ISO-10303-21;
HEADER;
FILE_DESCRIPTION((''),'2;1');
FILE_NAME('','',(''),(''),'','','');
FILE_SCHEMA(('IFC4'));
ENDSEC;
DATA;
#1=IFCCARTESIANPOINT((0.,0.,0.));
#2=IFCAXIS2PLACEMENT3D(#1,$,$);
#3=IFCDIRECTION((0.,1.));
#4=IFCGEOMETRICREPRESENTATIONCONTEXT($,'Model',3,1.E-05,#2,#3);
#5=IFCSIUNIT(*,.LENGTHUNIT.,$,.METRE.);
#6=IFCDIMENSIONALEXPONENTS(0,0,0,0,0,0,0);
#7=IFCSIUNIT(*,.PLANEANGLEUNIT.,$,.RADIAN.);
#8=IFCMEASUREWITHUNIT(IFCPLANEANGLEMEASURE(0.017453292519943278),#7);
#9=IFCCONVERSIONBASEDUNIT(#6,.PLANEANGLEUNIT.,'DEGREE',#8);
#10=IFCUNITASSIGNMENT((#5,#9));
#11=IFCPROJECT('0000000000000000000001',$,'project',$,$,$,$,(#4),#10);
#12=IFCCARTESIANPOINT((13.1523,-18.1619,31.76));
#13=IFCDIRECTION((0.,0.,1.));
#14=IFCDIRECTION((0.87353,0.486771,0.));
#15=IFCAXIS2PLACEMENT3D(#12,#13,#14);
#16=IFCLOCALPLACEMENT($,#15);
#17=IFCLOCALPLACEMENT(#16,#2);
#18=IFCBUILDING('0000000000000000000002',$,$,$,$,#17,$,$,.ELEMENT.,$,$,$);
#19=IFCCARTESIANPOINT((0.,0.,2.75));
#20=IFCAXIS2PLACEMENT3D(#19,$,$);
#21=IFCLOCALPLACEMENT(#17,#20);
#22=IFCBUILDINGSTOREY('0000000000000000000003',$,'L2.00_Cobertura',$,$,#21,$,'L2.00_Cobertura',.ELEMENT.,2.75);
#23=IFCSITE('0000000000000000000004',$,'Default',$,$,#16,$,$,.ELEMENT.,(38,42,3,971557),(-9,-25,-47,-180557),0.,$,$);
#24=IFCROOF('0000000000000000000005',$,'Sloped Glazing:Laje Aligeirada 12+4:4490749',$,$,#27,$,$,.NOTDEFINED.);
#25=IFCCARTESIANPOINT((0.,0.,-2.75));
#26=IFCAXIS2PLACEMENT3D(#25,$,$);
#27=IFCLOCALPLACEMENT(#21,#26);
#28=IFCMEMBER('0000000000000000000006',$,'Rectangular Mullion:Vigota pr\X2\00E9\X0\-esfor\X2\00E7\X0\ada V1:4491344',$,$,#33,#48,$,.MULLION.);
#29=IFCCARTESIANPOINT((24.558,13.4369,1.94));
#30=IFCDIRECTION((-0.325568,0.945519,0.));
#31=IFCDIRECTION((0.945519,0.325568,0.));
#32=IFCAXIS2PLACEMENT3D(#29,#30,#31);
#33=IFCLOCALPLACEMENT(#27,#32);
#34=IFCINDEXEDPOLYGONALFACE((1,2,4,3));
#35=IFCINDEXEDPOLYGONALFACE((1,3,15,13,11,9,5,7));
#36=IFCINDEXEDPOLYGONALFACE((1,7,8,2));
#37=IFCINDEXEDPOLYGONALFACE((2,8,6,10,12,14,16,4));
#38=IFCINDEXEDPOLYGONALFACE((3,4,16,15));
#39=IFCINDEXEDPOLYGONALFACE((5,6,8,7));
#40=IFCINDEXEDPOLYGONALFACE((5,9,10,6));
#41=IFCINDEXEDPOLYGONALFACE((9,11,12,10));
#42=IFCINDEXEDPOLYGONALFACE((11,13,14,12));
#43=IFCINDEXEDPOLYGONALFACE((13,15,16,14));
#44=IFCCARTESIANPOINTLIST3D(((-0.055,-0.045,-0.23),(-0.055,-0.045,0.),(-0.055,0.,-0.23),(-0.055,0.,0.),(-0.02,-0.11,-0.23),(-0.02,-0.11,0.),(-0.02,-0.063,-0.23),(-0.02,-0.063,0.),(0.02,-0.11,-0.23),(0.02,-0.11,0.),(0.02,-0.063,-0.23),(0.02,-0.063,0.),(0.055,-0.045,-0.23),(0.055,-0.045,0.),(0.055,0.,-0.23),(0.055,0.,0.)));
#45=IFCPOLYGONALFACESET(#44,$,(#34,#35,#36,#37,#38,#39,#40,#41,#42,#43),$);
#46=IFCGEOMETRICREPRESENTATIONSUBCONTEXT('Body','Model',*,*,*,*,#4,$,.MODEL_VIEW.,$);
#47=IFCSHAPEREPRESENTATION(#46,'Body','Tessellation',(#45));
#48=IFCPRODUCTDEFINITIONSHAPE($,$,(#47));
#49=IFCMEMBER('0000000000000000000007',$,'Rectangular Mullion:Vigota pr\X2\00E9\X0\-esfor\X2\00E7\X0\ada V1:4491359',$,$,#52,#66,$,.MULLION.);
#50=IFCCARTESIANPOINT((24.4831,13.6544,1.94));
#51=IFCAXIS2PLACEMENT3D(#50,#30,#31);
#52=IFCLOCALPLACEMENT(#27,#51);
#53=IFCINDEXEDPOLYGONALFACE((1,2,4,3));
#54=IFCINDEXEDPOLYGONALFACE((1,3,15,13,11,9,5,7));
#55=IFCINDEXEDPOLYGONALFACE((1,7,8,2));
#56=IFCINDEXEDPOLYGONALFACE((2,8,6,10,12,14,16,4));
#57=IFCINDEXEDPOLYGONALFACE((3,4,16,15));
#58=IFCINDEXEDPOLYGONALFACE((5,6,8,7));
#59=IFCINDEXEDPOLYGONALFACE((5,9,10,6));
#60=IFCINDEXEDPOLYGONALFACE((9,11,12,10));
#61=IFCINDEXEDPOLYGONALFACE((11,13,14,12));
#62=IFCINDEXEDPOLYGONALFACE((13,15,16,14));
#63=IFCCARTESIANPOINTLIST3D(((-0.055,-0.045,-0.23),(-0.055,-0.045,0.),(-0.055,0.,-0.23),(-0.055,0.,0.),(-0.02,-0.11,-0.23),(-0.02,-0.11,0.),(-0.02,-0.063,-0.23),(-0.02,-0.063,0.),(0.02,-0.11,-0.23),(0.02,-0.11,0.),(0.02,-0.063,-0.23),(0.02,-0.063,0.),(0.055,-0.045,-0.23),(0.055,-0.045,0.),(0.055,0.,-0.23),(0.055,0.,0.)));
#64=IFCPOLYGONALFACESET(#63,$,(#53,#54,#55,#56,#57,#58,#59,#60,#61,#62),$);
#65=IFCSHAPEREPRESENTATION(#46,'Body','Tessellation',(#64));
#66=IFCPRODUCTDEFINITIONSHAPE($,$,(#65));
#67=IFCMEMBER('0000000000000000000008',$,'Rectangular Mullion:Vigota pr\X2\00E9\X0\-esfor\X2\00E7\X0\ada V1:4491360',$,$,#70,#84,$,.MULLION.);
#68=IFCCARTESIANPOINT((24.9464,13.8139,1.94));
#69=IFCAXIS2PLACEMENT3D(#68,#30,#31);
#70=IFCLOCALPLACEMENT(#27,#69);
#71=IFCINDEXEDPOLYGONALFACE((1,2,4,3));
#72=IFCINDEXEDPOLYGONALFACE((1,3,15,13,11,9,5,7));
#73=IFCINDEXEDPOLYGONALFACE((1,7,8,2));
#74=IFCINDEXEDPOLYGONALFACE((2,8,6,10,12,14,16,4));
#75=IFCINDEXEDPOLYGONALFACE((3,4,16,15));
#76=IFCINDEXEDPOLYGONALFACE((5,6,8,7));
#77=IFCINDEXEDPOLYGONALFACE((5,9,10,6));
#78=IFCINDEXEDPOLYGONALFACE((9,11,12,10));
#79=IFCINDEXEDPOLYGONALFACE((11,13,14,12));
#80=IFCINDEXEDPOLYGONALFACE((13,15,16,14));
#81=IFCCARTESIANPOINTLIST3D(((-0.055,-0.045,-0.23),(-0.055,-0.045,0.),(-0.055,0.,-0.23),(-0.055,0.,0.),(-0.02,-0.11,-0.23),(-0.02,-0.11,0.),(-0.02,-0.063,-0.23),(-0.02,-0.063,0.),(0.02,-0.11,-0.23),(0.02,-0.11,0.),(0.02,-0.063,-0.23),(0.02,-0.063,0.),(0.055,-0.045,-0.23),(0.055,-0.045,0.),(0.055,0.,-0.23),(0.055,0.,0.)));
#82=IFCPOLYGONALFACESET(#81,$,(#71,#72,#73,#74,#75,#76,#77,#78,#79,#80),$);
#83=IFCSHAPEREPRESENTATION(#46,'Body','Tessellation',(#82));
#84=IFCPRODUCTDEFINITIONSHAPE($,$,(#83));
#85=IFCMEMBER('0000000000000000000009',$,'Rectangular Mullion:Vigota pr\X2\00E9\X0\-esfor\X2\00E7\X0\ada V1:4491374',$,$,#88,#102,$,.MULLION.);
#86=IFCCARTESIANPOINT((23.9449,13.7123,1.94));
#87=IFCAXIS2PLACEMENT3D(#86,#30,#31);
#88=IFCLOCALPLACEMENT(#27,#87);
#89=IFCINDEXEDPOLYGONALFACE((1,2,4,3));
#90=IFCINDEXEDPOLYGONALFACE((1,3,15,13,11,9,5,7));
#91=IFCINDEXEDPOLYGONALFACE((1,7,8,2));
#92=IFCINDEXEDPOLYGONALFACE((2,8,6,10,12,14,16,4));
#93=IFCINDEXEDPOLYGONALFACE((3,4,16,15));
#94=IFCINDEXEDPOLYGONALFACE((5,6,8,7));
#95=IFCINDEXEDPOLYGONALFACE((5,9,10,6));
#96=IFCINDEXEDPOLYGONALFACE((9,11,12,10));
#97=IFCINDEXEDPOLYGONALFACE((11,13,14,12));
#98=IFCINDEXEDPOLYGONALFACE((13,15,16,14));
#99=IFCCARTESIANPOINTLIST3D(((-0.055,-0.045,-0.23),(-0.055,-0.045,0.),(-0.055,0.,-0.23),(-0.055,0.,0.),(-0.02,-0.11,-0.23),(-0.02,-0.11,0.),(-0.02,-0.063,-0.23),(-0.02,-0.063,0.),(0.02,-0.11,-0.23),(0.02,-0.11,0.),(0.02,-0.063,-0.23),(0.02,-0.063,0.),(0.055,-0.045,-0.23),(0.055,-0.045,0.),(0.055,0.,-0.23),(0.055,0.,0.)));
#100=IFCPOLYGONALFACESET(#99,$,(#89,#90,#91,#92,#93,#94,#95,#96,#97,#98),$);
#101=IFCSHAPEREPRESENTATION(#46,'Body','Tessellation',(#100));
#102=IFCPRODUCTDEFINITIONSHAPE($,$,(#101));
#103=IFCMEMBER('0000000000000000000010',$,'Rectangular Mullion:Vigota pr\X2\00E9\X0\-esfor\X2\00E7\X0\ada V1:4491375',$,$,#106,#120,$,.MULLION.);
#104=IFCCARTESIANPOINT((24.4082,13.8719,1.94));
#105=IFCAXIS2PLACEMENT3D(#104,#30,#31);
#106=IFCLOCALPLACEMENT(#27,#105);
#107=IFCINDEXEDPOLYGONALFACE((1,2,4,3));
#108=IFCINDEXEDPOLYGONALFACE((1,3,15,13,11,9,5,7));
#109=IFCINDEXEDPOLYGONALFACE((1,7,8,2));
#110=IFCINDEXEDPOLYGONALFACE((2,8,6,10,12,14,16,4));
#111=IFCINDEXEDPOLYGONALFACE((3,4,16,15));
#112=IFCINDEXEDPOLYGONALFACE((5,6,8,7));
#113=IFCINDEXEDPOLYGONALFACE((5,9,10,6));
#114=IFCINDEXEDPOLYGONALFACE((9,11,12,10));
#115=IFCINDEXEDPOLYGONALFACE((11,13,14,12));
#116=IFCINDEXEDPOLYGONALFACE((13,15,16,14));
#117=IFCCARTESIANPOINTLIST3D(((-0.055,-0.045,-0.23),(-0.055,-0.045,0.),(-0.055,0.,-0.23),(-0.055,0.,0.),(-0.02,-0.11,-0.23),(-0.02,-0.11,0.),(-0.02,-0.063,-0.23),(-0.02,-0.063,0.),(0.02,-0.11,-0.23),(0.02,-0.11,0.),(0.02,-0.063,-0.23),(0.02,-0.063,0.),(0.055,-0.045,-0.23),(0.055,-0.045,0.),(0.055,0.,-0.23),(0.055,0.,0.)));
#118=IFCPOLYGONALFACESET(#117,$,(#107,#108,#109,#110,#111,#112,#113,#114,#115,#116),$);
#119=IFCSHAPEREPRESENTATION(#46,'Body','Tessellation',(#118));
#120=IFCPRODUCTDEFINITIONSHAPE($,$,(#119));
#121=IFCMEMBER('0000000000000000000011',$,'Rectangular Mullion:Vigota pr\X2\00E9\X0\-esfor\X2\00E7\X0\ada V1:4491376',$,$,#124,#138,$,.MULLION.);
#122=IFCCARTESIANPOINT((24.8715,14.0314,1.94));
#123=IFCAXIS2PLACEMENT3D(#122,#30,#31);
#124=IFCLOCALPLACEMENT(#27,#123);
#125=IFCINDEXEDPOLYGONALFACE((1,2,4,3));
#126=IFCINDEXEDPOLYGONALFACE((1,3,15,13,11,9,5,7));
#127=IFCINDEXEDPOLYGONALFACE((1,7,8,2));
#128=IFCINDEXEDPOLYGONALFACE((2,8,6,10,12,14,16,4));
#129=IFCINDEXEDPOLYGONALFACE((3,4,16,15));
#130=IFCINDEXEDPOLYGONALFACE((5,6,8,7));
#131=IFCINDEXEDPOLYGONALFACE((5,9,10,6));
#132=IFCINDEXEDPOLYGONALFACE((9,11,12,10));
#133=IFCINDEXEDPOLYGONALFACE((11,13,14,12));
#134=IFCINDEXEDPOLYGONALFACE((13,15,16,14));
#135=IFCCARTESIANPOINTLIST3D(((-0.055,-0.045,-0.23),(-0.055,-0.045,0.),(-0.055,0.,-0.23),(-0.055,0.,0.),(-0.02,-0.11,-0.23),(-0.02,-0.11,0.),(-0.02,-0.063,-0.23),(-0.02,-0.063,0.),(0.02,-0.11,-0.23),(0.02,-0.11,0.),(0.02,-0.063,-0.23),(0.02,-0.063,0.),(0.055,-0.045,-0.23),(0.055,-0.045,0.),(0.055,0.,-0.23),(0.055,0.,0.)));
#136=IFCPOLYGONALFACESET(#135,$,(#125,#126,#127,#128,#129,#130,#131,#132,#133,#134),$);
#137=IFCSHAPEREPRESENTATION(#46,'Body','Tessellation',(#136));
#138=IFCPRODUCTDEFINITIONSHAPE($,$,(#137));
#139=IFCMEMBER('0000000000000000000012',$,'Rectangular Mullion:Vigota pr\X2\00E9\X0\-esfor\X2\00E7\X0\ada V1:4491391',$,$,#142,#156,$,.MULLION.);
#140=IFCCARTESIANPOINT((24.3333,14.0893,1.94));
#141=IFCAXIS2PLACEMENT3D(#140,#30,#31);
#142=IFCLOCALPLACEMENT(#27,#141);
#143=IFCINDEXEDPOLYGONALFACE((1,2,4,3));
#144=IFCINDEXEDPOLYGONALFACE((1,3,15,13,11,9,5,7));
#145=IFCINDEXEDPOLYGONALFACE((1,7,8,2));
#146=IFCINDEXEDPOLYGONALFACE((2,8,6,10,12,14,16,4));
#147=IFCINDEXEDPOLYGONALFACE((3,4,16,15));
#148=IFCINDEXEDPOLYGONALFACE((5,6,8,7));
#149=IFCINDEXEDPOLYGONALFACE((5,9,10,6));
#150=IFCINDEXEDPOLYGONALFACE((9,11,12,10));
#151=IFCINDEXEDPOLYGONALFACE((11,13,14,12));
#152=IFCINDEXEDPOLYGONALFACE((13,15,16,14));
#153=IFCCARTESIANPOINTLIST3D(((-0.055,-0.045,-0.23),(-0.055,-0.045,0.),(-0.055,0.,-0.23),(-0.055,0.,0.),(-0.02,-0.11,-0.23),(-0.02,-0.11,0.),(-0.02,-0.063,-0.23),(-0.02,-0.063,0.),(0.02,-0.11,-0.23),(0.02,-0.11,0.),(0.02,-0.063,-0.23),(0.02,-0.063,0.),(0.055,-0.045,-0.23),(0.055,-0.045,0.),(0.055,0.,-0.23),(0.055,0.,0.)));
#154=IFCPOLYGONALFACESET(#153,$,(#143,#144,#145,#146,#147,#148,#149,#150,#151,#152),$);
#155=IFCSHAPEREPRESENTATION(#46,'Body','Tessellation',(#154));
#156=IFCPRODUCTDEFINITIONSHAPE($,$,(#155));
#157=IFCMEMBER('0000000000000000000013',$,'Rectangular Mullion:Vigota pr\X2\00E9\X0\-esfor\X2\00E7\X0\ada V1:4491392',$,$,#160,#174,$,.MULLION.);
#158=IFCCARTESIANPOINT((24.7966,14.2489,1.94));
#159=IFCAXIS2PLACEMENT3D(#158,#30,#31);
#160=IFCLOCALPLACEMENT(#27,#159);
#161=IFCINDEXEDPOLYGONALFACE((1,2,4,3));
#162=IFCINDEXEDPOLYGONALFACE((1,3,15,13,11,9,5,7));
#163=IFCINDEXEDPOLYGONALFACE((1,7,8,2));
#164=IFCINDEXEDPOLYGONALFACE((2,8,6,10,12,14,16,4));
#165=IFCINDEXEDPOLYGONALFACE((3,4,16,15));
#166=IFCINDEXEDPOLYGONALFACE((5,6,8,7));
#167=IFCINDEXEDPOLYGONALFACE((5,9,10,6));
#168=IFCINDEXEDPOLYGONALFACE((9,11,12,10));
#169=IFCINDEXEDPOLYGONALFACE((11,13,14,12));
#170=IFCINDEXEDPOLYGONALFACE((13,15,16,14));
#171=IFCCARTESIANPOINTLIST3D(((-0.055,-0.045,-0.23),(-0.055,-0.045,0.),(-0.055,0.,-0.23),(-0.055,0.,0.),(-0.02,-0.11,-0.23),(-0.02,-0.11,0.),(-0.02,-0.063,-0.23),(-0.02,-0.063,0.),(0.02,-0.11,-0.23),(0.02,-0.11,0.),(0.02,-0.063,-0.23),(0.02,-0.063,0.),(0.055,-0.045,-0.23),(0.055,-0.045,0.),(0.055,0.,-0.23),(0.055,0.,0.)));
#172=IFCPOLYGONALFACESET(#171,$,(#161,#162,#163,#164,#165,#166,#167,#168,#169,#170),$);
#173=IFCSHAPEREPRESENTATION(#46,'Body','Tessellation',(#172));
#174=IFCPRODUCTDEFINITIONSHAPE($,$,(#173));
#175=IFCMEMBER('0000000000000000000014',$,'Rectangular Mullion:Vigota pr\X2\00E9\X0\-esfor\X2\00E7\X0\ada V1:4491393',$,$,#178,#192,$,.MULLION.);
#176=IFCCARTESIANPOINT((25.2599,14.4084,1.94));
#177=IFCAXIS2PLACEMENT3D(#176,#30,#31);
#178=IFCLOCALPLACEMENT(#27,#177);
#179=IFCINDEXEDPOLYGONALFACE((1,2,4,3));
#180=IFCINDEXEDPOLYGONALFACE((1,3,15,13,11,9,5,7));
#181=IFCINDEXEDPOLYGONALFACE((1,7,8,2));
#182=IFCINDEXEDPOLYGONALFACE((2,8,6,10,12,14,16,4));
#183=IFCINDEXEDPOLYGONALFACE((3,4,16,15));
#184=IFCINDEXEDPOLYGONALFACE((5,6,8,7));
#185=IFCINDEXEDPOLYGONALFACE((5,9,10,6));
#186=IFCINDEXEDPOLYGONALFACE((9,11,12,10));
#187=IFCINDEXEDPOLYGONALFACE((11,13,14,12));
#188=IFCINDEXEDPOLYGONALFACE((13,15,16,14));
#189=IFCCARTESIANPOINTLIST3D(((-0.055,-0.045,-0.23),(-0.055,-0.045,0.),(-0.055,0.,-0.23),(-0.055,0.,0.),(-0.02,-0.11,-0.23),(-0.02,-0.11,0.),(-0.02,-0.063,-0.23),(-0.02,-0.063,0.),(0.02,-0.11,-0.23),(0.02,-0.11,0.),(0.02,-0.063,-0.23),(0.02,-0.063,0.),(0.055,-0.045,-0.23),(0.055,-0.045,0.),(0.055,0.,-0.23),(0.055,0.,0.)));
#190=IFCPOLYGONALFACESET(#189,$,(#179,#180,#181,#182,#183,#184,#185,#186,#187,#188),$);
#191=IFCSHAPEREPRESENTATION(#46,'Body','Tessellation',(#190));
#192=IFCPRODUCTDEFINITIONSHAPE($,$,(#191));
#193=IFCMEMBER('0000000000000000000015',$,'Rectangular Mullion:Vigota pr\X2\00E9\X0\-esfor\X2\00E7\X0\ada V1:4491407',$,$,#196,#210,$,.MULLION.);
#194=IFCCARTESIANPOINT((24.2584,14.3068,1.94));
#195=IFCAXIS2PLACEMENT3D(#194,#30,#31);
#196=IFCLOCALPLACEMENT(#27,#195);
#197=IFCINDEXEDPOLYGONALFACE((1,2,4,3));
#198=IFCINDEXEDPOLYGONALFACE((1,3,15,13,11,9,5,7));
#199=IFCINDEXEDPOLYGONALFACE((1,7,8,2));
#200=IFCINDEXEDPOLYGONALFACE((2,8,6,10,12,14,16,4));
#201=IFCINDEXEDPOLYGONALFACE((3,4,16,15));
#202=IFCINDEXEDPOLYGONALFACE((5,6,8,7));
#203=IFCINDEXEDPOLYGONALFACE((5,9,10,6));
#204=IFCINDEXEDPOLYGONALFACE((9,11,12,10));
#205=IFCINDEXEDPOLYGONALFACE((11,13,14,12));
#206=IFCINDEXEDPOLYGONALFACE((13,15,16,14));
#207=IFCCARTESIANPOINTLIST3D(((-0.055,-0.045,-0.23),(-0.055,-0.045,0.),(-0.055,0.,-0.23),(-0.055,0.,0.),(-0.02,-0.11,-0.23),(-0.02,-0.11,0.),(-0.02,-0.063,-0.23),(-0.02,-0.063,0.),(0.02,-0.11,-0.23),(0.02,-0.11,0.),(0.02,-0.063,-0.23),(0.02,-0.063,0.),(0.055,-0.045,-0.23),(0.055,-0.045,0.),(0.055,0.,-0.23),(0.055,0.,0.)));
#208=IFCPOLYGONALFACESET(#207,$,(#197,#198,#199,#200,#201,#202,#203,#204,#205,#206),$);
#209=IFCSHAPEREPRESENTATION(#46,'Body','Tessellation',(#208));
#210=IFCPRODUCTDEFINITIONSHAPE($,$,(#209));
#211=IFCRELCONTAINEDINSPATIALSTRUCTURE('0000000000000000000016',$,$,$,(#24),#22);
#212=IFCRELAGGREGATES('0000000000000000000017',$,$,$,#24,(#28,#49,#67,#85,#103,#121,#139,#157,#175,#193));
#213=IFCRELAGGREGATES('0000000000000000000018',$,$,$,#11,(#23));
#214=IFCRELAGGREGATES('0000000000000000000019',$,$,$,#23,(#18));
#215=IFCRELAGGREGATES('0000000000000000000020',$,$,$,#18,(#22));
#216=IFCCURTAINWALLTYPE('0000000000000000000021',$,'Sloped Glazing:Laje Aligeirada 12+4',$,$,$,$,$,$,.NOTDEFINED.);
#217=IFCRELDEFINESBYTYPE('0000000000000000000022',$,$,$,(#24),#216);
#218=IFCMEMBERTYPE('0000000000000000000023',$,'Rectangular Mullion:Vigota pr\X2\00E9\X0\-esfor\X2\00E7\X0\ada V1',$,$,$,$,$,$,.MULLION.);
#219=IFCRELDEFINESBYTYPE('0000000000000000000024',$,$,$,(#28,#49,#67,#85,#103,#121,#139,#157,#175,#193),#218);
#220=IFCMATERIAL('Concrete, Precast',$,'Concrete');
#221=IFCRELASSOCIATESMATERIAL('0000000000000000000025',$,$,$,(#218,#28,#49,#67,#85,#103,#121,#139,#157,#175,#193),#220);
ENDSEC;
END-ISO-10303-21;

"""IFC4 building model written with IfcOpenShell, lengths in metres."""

from ifc_helpers import new_model, entity, si_unit, converted_unit, direction, frame, origin, place, context, subcontext, project, spatial, indexed_curve, outline, extrude, source, transform, mapped, material, type_object, type_shapes, element, aggregate, save


model = new_model("IFC4")

# Units and contexts
model_context = context("Model", 3, precision=1e-05, world=origin(), true_north=direction((0.0, 1.0)))
body_context = subcontext(model_context, "Body", "Model", "MODEL_VIEW")
ifc_project = project(units=[si_unit("LENGTHUNIT", "METRE"), converted_unit("PLANEANGLEUNIT", "DEGREE", entity("IfcPlaneAngleMeasure", 0.017453292519943278), si_unit("PLANEANGLEUNIT", "RADIAN"), dimensions=[0, 0, 0, 0, 0, 0, 0])], contexts=[model_context])

# Site, building, storey
site_placement = place(None, frame((13.1523, -18.1619, 31.76), z_axis=(0.0, 0.0, 1.0), x_axis=(0.87353, 0.486771, 0.0)))
site = spatial("IfcSite", under=ifc_project, at=site_placement, Name="Default", CompositionType="ELEMENT", RefLatitude=(38, 42, 3, 971557), RefLongitude=(-9, -25, -47, -180557), RefElevation=0.0)
building_placement = place(site_placement, origin())
building = spatial("IfcBuilding", under=site, at=building_placement, CompositionType="ELEMENT")
storey_placement = place(building_placement, frame((0.0, 0.0, 2.75)))
storey = spatial("IfcBuildingStorey", under=building, at=storey_placement, Name="L2.00_Cobertura", LongName="L2.00_Cobertura", CompositionType="ELEMENT", Elevation=2.75)

# Roof, members
curtain_wall_type = type_object("IfcCurtainWallType", Name="Sloped Glazing:Laje Aligeirada 12+4", PredefinedType="NOTDEFINED")
roof_placement = place(storey_placement, frame((0.0, 0.0, -2.75)))
roof = element("IfcRoof", 1, at=roof_placement, inside=storey, type_object=curtain_wall_type, Name="Sloped Glazing:Laje Aligeirada 12+4:4490749", PredefinedType="NOTDEFINED")
ifc_material_1 = material(Name="Concrete, Precast", Category="Concrete")
member_type_1 = type_object("IfcMemberType", Name="Rectangular Mullion:Vigota pré-esforçada V1", PredefinedType="MULLION", material=ifc_material_1)
shared_shape_1 = source(origin(), body_context, "Body", "SweptSolid", [
    extrude(outline(indexed_curve([(-0.055, -0.0545), (0.055, -0.0545), (0.055, -0.0095), (0.02, 0.0085), (0.02, 0.0555), (-0.02, 0.0555), (-0.02, 0.0085), (-0.055, -0.0095), (-0.055, -0.0545)], self_intersect=False)), frame((0.0, -0.0545, -0.23), z_axis=(0.0, 0.0, 1.0), x_axis=(-1.0, 0.0, 0.0)), (0.0, 0.0, 1.0), 0.23),
])
type_shapes(member_type_1, [shared_shape_1])
member_1_placement = place(roof_placement, frame((24.558, 13.4369, 1.94), z_axis=(-0.325568, 0.945519, 0.0), x_axis=(0.945519, 0.325568, 0.0)))
member_1 = element("IfcMember", 2, at=member_1_placement, type_object=member_type_1, material=ifc_material_1, Name="Rectangular Mullion:Vigota pré-esforçada V1:4491344", PredefinedType="MULLION", context=body_context, shape_type="MappedRepresentation", body=[
    mapped(shared_shape_1, transform((0.0, 0.0, 0.0), scale=1.0)),
])
member_2_placement = place(roof_placement, frame((24.4831, 13.6544, 1.94), z_axis=(-0.325568, 0.945519, 0.0), x_axis=(0.945519, 0.325568, 0.0)))
member_2 = element("IfcMember", 3, at=member_2_placement, type_object=member_type_1, material=ifc_material_1, Name="Rectangular Mullion:Vigota pré-esforçada V1:4491359", PredefinedType="MULLION", context=body_context, shape_type="MappedRepresentation", body=[
    mapped(shared_shape_1, transform((0.0, 0.0, 0.0), scale=1.0)),
])
member_3_placement = place(roof_placement, frame((24.9464, 13.8139, 1.94), z_axis=(-0.325568, 0.945519, 0.0), x_axis=(0.945519, 0.325568, 0.0)))
member_3 = element("IfcMember", 4, at=member_3_placement, type_object=member_type_1, material=ifc_material_1, Name="Rectangular Mullion:Vigota pré-esforçada V1:4491360", PredefinedType="MULLION", context=body_context, shape_type="MappedRepresentation", body=[
    mapped(shared_shape_1, transform((0.0, 0.0, 0.0), scale=1.0)),
])
member_4_placement = place(roof_placement, frame((23.9449, 13.7123, 1.94), z_axis=(-0.325568, 0.945519, 0.0), x_axis=(0.945519, 0.325568, 0.0)))
member_4 = element("IfcMember", 5, at=member_4_placement, type_object=member_type_1, material=ifc_material_1, Name="Rectangular Mullion:Vigota pré-esforçada V1:4491374", PredefinedType="MULLION", context=body_context, shape_type="MappedRepresentation", body=[
    mapped(shared_shape_1, transform((0.0, 0.0, 0.0), scale=1.0)),
])
member_5_placement = place(roof_placement, frame((24.4082, 13.8719, 1.94), z_axis=(-0.325568, 0.945519, 0.0), x_axis=(0.945519, 0.325568, 0.0)))
member_5 = element("IfcMember", 6, at=member_5_placement, type_object=member_type_1, material=ifc_material_1, Name="Rectangular Mullion:Vigota pré-esforçada V1:4491375", PredefinedType="MULLION", context=body_context, shape_type="MappedRepresentation", body=[
    mapped(shared_shape_1, transform((0.0, 0.0, 0.0), scale=1.0)),
])
member_6_placement = place(roof_placement, frame((24.8715, 14.0314, 1.94), z_axis=(-0.325568, 0.945519, 0.0), x_axis=(0.945519, 0.325568, 0.0)))
member_6 = element("IfcMember", 7, at=member_6_placement, type_object=member_type_1, material=ifc_material_1, Name="Rectangular Mullion:Vigota pré-esforçada V1:4491376", PredefinedType="MULLION", context=body_context, shape_type="MappedRepresentation", body=[
    mapped(shared_shape_1, transform((0.0, 0.0, 0.0), scale=1.0)),
])
member_7_placement = place(roof_placement, frame((24.3333, 14.0893, 1.94), z_axis=(-0.325568, 0.945519, 0.0), x_axis=(0.945519, 0.325568, 0.0)))
member_7 = element("IfcMember", 8, at=member_7_placement, type_object=member_type_1, material=ifc_material_1, Name="Rectangular Mullion:Vigota pré-esforçada V1:4491391", PredefinedType="MULLION", context=body_context, shape_type="MappedRepresentation", body=[
    mapped(shared_shape_1, transform((0.0, 0.0, 0.0), scale=1.0)),
])
member_8_placement = place(roof_placement, frame((24.7966, 14.2489, 1.94), z_axis=(-0.325568, 0.945519, 0.0), x_axis=(0.945519, 0.325568, 0.0)))
member_8 = element("IfcMember", 9, at=member_8_placement, type_object=member_type_1, material=ifc_material_1, Name="Rectangular Mullion:Vigota pré-esforçada V1:4491392", PredefinedType="MULLION", context=body_context, shape_type="MappedRepresentation", body=[
    mapped(shared_shape_1, transform((0.0, 0.0, 0.0), scale=1.0)),
])
member_9_placement = place(roof_placement, frame((25.2599, 14.4084, 1.94), z_axis=(-0.325568, 0.945519, 0.0), x_axis=(0.945519, 0.325568, 0.0)))
member_9 = element("IfcMember", 10, at=member_9_placement, type_object=member_type_1, material=ifc_material_1, Name="Rectangular Mullion:Vigota pré-esforçada V1:4491393", PredefinedType="MULLION", context=body_context, shape_type="MappedRepresentation", body=[
    mapped(shared_shape_1, transform((0.0, 0.0, 0.0), scale=1.0)),
])
member_10_placement = place(roof_placement, frame((24.2584, 14.3068, 1.94), z_axis=(-0.325568, 0.945519, 0.0), x_axis=(0.945519, 0.325568, 0.0)))
member_10 = element("IfcMember", 11, at=member_10_placement, type_object=member_type_1, material=ifc_material_1, Name="Rectangular Mullion:Vigota pré-esforçada V1:4491407", PredefinedType="MULLION", context=body_context, shape_type="MappedRepresentation", body=[
    mapped(shared_shape_1, transform((0.0, 0.0, 0.0), scale=1.0)),
])
aggregate(roof, [member_1, member_2, member_3, member_4, member_5, member_6, member_7, member_8, member_9, member_10])

save(model, "model.ifc")
